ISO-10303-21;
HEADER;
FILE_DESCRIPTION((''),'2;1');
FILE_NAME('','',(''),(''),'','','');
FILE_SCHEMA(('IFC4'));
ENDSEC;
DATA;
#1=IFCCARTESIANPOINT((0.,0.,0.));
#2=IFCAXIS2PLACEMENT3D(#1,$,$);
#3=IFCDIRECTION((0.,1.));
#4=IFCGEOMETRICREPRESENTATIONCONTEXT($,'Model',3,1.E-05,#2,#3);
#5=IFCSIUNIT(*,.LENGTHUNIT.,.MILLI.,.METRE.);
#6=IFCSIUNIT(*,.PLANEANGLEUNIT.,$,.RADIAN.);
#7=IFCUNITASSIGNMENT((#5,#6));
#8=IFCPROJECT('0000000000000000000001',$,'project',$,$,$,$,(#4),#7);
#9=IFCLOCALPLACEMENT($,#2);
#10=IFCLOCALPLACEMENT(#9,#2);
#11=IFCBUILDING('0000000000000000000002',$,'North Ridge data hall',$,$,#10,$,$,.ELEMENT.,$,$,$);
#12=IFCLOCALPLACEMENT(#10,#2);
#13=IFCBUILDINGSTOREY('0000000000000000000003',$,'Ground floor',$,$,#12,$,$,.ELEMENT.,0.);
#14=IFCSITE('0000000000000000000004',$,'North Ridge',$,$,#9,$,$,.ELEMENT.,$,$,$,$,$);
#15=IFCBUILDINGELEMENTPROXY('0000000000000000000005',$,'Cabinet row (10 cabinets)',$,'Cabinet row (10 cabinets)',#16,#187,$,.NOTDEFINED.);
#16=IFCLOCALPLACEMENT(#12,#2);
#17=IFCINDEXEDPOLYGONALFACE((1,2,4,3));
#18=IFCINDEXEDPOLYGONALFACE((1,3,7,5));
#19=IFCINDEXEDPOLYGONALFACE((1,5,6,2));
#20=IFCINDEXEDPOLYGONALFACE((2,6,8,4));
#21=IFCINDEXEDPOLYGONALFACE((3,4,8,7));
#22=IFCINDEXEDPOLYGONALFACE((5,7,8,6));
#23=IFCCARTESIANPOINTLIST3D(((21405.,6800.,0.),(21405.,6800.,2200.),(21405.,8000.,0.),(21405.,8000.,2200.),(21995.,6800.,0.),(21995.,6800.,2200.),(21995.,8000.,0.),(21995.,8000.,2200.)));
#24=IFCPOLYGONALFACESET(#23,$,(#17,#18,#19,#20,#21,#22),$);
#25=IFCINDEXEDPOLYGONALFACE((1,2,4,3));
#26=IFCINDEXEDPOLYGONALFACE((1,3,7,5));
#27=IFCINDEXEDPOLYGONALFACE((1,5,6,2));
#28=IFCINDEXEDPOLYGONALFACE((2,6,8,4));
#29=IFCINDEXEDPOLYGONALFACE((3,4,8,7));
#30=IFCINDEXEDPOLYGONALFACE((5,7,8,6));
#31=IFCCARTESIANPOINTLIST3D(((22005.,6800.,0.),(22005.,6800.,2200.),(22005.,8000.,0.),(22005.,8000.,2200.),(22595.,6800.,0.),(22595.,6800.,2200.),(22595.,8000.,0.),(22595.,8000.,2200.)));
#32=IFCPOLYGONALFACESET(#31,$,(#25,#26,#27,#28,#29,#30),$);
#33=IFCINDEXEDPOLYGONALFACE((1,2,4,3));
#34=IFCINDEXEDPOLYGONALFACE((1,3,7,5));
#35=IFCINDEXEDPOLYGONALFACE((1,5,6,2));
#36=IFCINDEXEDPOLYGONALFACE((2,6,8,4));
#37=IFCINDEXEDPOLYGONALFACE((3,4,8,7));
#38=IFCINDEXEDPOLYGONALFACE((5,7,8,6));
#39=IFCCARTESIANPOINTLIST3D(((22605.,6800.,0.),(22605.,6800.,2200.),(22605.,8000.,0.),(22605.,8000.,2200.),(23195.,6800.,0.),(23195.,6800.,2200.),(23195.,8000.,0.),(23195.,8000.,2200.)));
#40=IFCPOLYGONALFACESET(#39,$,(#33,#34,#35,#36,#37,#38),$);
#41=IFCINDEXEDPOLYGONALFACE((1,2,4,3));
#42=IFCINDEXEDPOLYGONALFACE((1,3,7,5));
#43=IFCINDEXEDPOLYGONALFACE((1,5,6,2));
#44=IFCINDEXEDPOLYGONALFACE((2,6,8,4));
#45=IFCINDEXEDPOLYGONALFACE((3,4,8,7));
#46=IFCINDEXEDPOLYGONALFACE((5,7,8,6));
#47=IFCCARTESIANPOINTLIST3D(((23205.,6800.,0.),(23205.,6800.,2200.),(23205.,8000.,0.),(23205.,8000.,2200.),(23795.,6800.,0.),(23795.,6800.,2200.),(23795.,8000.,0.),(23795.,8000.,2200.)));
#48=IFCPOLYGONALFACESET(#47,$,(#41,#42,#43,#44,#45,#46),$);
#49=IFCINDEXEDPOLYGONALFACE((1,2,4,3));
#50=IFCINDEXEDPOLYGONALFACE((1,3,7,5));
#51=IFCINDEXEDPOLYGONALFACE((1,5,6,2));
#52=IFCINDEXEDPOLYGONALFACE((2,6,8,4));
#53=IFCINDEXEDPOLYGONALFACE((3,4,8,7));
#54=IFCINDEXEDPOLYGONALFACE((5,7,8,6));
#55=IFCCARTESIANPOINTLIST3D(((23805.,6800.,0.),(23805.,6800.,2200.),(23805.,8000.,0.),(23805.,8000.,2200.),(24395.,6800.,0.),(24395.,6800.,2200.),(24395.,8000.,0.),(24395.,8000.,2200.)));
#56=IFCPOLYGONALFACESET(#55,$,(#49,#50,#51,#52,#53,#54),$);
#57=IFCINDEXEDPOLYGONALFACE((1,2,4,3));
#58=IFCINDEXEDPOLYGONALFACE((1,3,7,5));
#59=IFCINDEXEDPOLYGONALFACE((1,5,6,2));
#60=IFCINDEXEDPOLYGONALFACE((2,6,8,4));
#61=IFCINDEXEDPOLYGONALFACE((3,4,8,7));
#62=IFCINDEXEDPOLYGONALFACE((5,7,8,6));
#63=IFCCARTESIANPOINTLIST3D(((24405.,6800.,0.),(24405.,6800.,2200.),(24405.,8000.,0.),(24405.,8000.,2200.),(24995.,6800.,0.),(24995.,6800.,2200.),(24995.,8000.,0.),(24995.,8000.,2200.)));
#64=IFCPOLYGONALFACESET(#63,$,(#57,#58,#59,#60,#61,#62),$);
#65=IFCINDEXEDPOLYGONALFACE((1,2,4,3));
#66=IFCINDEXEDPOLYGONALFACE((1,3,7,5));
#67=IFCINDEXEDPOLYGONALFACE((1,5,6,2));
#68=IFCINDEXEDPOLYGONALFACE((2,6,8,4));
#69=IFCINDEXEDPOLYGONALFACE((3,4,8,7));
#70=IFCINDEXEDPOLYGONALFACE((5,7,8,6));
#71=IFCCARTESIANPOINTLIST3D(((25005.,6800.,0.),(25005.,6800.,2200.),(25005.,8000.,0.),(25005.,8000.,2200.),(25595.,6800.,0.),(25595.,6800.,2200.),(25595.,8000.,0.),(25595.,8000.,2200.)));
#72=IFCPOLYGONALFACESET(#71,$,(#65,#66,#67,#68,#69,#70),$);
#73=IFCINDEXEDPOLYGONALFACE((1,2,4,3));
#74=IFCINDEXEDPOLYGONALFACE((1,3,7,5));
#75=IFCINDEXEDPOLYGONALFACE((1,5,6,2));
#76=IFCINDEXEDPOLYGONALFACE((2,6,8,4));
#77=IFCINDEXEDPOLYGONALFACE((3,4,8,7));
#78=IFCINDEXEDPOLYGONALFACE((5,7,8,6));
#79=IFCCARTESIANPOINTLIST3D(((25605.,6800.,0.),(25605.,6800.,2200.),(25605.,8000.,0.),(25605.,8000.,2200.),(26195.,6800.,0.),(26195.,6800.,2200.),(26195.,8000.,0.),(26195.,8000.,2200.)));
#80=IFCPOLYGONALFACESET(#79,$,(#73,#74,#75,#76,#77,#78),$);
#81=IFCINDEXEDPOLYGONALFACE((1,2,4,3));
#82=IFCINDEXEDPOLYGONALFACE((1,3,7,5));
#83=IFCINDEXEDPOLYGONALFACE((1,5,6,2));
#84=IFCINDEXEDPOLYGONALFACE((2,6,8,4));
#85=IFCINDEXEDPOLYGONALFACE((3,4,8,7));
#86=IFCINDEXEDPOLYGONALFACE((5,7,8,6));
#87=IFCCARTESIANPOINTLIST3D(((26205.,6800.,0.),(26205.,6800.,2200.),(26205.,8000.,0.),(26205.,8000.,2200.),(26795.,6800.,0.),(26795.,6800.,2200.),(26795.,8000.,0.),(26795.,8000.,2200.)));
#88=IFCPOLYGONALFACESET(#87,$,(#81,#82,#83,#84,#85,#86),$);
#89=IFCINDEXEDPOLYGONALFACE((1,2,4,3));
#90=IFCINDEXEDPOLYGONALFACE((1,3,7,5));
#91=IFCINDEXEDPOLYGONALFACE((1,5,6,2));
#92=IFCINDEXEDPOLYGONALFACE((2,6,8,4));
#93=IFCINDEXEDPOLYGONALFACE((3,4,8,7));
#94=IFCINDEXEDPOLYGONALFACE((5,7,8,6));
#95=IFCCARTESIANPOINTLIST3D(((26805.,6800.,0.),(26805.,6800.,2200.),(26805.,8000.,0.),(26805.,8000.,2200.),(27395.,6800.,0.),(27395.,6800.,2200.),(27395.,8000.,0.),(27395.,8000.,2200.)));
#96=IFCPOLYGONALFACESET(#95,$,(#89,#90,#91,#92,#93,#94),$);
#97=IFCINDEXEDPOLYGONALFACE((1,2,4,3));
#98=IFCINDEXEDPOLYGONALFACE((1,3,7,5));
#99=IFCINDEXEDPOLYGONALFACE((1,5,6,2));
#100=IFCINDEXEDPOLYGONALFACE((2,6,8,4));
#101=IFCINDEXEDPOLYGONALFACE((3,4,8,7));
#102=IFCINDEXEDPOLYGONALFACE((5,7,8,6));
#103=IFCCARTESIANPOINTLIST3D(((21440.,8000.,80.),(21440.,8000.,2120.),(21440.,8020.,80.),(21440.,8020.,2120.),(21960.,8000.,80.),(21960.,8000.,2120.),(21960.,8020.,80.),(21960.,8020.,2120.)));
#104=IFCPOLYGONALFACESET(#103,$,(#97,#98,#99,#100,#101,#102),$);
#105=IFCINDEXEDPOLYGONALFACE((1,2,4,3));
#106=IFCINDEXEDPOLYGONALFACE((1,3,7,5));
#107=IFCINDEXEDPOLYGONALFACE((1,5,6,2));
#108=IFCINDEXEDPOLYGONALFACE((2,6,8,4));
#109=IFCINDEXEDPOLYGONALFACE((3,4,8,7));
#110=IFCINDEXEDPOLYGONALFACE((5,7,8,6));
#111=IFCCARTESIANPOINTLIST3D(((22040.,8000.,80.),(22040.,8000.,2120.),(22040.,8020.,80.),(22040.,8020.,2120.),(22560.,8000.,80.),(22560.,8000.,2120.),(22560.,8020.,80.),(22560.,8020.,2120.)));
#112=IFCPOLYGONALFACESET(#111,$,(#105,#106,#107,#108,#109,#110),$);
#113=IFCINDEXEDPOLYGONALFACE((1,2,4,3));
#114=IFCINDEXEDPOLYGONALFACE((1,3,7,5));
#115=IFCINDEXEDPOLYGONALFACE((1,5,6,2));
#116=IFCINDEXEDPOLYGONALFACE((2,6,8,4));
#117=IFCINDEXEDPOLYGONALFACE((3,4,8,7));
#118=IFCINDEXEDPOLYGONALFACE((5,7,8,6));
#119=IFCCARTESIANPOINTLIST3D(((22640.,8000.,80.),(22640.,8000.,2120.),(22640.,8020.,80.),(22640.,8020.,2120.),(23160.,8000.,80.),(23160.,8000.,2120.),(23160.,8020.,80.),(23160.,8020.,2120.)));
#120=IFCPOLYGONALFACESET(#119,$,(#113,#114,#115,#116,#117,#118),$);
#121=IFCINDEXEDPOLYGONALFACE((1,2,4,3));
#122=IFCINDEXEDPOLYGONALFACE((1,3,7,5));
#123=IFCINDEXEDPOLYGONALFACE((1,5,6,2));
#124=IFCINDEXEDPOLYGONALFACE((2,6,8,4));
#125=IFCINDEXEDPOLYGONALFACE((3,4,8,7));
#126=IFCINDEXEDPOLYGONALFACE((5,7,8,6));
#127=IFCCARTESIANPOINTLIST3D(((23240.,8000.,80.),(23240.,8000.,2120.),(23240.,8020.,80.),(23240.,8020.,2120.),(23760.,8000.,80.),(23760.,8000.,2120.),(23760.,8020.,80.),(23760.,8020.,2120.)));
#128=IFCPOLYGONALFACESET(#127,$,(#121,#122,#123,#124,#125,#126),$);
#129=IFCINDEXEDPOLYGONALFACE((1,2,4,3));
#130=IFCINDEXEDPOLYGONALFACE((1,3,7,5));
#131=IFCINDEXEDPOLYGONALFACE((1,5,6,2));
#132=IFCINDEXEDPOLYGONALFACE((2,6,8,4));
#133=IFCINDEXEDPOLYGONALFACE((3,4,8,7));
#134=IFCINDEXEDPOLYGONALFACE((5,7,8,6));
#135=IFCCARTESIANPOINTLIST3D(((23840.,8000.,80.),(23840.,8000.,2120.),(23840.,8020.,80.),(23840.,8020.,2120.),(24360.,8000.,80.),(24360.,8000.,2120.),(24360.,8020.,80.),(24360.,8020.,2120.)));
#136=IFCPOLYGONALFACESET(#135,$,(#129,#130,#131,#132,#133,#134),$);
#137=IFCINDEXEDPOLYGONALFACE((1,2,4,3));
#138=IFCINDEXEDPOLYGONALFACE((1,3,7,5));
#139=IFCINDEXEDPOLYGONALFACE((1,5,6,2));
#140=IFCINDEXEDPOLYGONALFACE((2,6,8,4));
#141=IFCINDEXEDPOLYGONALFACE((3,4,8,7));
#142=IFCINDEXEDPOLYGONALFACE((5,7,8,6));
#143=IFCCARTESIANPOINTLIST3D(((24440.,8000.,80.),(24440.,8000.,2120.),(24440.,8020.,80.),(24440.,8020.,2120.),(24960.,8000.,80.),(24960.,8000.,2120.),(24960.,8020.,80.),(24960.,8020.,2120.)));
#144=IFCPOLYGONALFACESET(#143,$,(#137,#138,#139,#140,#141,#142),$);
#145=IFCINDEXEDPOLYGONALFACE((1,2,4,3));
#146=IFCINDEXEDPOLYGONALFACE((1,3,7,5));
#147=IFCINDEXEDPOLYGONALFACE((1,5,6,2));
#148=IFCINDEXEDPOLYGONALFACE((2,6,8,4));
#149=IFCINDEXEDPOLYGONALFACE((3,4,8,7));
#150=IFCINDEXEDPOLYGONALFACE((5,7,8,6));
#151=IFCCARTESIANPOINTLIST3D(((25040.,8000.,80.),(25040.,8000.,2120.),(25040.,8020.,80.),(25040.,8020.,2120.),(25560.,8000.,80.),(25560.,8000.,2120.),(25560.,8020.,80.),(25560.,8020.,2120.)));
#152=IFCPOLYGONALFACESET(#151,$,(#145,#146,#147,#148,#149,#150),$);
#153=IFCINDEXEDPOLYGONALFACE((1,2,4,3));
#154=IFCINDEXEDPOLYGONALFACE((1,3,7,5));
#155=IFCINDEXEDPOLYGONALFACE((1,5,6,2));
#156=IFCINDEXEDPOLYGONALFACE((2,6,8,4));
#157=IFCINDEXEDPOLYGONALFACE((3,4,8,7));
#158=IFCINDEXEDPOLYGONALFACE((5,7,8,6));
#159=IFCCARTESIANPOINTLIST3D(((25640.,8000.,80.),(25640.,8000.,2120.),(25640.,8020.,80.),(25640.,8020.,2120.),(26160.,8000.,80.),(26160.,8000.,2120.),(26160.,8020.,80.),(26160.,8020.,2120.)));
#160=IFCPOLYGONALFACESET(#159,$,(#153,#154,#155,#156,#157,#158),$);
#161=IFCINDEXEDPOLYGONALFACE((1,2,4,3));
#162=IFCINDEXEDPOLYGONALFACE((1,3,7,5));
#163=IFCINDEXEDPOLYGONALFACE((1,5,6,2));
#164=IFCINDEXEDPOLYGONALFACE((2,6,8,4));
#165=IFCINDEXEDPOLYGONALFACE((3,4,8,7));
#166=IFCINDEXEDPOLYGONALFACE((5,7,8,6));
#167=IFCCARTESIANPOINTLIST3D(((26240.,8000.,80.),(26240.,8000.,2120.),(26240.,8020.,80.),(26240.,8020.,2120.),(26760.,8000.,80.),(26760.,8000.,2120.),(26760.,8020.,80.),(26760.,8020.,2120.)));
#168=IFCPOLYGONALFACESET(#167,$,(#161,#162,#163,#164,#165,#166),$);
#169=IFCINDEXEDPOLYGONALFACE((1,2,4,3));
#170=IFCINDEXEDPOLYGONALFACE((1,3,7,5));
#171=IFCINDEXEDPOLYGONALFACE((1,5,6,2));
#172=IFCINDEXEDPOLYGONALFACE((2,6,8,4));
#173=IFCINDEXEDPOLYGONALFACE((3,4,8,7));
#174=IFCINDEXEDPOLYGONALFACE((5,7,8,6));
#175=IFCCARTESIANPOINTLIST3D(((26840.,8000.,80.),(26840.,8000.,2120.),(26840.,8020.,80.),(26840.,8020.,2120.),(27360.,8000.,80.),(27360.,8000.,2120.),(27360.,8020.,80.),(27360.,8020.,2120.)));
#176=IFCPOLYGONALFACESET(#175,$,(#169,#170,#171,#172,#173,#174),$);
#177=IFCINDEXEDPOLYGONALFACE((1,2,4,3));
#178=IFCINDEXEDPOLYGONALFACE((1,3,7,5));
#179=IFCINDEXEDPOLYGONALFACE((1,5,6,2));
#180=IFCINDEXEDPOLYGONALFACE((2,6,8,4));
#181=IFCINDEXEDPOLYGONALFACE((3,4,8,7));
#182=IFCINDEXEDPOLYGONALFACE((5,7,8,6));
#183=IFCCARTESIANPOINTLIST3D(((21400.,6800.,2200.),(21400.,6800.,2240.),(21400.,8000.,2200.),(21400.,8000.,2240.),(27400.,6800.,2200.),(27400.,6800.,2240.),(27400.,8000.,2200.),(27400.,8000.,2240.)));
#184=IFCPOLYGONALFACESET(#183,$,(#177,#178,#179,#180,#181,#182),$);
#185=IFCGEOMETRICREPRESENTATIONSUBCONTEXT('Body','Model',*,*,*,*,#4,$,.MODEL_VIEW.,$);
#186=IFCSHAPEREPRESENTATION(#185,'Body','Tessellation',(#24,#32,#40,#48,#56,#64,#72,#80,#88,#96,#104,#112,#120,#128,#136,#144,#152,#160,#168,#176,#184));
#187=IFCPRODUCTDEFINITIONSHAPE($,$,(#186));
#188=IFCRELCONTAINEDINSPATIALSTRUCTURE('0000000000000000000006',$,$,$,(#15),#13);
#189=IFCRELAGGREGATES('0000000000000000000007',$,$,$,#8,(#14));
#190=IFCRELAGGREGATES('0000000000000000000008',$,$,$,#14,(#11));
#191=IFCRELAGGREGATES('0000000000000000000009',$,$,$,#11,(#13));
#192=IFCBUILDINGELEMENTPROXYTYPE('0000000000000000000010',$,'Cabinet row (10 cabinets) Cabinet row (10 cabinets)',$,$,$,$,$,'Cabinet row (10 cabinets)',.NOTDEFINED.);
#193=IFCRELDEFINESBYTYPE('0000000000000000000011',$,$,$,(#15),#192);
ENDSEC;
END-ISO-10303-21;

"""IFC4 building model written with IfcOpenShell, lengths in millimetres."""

from ifc_helpers import new_model, si_unit, direction, frame, origin, place, context, subcontext, project, spatial, polyline, outline, extrude, source, transform, mapped, type_object, type_shapes, element, save


model = new_model("IFC4")

# Units and contexts
model_context = context("Model", 3, precision=1e-05, world=origin(), true_north=direction((0.0, 1.0)))
body_context = subcontext(model_context, "Body", "Model", "MODEL_VIEW")
ifc_project = project(units=[si_unit("LENGTHUNIT", "METRE", prefix="MILLI"), si_unit("PLANEANGLEUNIT", "RADIAN")], contexts=[model_context])

# Site, building, storey
site_placement = place(None, origin())
site = spatial("IfcSite", under=ifc_project, at=site_placement, Name="North Ridge", CompositionType="ELEMENT")
building_placement = place(site_placement, origin())
building = spatial("IfcBuilding", under=site, at=building_placement, Name="North Ridge data hall", CompositionType="ELEMENT")
storey_placement = place(building_placement, origin())
storey = spatial("IfcBuildingStorey", under=building, at=storey_placement, Name="Ground floor", CompositionType="ELEMENT", Elevation=0.0)

# Building element proxy
building_element_proxy_type_1 = type_object("IfcBuildingElementProxyType", Name="Cabinet row (10 cabinets) Cabinet row (10 cabinets)", ElementType="Cabinet row (10 cabinets)", PredefinedType="NOTDEFINED")
shared_shape_1 = source(origin(), body_context, "Body", "SweptSolid", [
    extrude(outline(polyline([(5.0, 0.0), (595.0, 0.0), (595.0, 1200.0), (5.0, 1200.0), (5.0, 0.0)])), origin(), (0.0, 0.0, 1.0), 2200.0),
    extrude(outline(polyline([(605.0, 0.0), (1195.0, 0.0), (1195.0, 1200.0), (605.0, 1200.0), (605.0, 0.0)])), origin(), (0.0, 0.0, 1.0), 2200.0),
    extrude(outline(polyline([(1205.0, 0.0), (1795.0, 0.0), (1795.0, 1200.0), (1205.0, 1200.0), (1205.0, 0.0)])), origin(), (0.0, 0.0, 1.0), 2200.0),
    extrude(outline(polyline([(1805.0, 0.0), (2395.0, 0.0), (2395.0, 1200.0), (1805.0, 1200.0), (1805.0, 0.0)])), origin(), (0.0, 0.0, 1.0), 2200.0),
    extrude(outline(polyline([(2405.0, 0.0), (2995.0, 0.0), (2995.0, 1200.0), (2405.0, 1200.0), (2405.0, 0.0)])), origin(), (0.0, 0.0, 1.0), 2200.0),
    extrude(outline(polyline([(3005.0, 0.0), (3595.0, 0.0), (3595.0, 1200.0), (3005.0, 1200.0), (3005.0, 0.0)])), origin(), (0.0, 0.0, 1.0), 2200.0),
    extrude(outline(polyline([(3605.0, 0.0), (4195.0, 0.0), (4195.0, 1200.0), (3605.0, 1200.0), (3605.0, 0.0)])), origin(), (0.0, 0.0, 1.0), 2200.0),
    extrude(outline(polyline([(4205.0, 0.0), (4795.0, 0.0), (4795.0, 1200.0), (4205.0, 1200.0), (4205.0, 0.0)])), origin(), (0.0, 0.0, 1.0), 2200.0),
    extrude(outline(polyline([(4805.0, 0.0), (5395.0, 0.0), (5395.0, 1200.0), (4805.0, 1200.0), (4805.0, 0.0)])), origin(), (0.0, 0.0, 1.0), 2200.0),
    extrude(outline(polyline([(5405.0, 0.0), (5995.0, 0.0), (5995.0, 1200.0), (5405.0, 1200.0), (5405.0, 0.0)])), origin(), (0.0, 0.0, 1.0), 2200.0),
    extrude(outline(polyline([(40.0, 1200.0), (560.0, 1200.0), (560.0, 1220.0), (40.0, 1220.0), (40.0, 1200.0)])), frame((0.0, 0.0, 80.0)), (0.0, 0.0, 1.0), 2040.0),
    extrude(outline(polyline([(640.0, 1200.0), (1160.0, 1200.0), (1160.0, 1220.0), (640.0, 1220.0), (640.0, 1200.0)])), frame((0.0, 0.0, 80.0)), (0.0, 0.0, 1.0), 2040.0),
    extrude(outline(polyline([(1240.0, 1200.0), (1760.0, 1200.0), (1760.0, 1220.0), (1240.0, 1220.0), (1240.0, 1200.0)])), frame((0.0, 0.0, 80.0)), (0.0, 0.0, 1.0), 2040.0),
    extrude(outline(polyline([(1840.0, 1200.0), (2360.0, 1200.0), (2360.0, 1220.0), (1840.0, 1220.0), (1840.0, 1200.0)])), frame((0.0, 0.0, 80.0)), (0.0, 0.0, 1.0), 2040.0),
    extrude(outline(polyline([(2440.0, 1200.0), (2960.0, 1200.0), (2960.0, 1220.0), (2440.0, 1220.0), (2440.0, 1200.0)])), frame((0.0, 0.0, 80.0)), (0.0, 0.0, 1.0), 2040.0),
    extrude(outline(polyline([(3040.0, 1200.0), (3560.0, 1200.0), (3560.0, 1220.0), (3040.0, 1220.0), (3040.0, 1200.0)])), frame((0.0, 0.0, 80.0)), (0.0, 0.0, 1.0), 2040.0),
    extrude(outline(polyline([(3640.0, 1200.0), (4160.0, 1200.0), (4160.0, 1220.0), (3640.0, 1220.0), (3640.0, 1200.0)])), frame((0.0, 0.0, 80.0)), (0.0, 0.0, 1.0), 2040.0),
    extrude(outline(polyline([(4240.0, 1200.0), (4760.0, 1200.0), (4760.0, 1220.0), (4240.0, 1220.0), (4240.0, 1200.0)])), frame((0.0, 0.0, 80.0)), (0.0, 0.0, 1.0), 2040.0),
    extrude(outline(polyline([(4840.0, 1200.0), (5360.0, 1200.0), (5360.0, 1220.0), (4840.0, 1220.0), (4840.0, 1200.0)])), frame((0.0, 0.0, 80.0)), (0.0, 0.0, 1.0), 2040.0),
    extrude(outline(polyline([(5440.0, 1200.0), (5960.0, 1200.0), (5960.0, 1220.0), (5440.0, 1220.0), (5440.0, 1200.0)])), frame((0.0, 0.0, 80.0)), (0.0, 0.0, 1.0), 2040.0),
    extrude(outline(polyline([(0.0, 0.0), (6000.0, 0.0), (6000.0, 1200.0), (0.0, 1200.0), (0.0, 0.0)])), frame((0.0, 0.0, 2200.0)), (0.0, 0.0, 1.0), 40.0),
])
type_shapes(building_element_proxy_type_1, [shared_shape_1])
for number, where, z_axis, x_axis, name in (
    (1, (21400.0, 6800.0, 0.0), (0.0, 0.0, 1.0), (1.0, 0.0, 0.0), "Cabinet row (10 cabinets)"),
):
    element("IfcBuildingElementProxy", number, at=place(storey_placement, frame(where, z_axis=z_axis, x_axis=x_axis)), inside=storey, type_object=building_element_proxy_type_1, Name=name, ObjectType="Cabinet row (10 cabinets)", PredefinedType="NOTDEFINED", context=body_context, shape_type="MappedRepresentation", body=[
        mapped(shared_shape_1, transform((0.0, 0.0, 0.0))),
    ])

save(model, "model.ifc")
